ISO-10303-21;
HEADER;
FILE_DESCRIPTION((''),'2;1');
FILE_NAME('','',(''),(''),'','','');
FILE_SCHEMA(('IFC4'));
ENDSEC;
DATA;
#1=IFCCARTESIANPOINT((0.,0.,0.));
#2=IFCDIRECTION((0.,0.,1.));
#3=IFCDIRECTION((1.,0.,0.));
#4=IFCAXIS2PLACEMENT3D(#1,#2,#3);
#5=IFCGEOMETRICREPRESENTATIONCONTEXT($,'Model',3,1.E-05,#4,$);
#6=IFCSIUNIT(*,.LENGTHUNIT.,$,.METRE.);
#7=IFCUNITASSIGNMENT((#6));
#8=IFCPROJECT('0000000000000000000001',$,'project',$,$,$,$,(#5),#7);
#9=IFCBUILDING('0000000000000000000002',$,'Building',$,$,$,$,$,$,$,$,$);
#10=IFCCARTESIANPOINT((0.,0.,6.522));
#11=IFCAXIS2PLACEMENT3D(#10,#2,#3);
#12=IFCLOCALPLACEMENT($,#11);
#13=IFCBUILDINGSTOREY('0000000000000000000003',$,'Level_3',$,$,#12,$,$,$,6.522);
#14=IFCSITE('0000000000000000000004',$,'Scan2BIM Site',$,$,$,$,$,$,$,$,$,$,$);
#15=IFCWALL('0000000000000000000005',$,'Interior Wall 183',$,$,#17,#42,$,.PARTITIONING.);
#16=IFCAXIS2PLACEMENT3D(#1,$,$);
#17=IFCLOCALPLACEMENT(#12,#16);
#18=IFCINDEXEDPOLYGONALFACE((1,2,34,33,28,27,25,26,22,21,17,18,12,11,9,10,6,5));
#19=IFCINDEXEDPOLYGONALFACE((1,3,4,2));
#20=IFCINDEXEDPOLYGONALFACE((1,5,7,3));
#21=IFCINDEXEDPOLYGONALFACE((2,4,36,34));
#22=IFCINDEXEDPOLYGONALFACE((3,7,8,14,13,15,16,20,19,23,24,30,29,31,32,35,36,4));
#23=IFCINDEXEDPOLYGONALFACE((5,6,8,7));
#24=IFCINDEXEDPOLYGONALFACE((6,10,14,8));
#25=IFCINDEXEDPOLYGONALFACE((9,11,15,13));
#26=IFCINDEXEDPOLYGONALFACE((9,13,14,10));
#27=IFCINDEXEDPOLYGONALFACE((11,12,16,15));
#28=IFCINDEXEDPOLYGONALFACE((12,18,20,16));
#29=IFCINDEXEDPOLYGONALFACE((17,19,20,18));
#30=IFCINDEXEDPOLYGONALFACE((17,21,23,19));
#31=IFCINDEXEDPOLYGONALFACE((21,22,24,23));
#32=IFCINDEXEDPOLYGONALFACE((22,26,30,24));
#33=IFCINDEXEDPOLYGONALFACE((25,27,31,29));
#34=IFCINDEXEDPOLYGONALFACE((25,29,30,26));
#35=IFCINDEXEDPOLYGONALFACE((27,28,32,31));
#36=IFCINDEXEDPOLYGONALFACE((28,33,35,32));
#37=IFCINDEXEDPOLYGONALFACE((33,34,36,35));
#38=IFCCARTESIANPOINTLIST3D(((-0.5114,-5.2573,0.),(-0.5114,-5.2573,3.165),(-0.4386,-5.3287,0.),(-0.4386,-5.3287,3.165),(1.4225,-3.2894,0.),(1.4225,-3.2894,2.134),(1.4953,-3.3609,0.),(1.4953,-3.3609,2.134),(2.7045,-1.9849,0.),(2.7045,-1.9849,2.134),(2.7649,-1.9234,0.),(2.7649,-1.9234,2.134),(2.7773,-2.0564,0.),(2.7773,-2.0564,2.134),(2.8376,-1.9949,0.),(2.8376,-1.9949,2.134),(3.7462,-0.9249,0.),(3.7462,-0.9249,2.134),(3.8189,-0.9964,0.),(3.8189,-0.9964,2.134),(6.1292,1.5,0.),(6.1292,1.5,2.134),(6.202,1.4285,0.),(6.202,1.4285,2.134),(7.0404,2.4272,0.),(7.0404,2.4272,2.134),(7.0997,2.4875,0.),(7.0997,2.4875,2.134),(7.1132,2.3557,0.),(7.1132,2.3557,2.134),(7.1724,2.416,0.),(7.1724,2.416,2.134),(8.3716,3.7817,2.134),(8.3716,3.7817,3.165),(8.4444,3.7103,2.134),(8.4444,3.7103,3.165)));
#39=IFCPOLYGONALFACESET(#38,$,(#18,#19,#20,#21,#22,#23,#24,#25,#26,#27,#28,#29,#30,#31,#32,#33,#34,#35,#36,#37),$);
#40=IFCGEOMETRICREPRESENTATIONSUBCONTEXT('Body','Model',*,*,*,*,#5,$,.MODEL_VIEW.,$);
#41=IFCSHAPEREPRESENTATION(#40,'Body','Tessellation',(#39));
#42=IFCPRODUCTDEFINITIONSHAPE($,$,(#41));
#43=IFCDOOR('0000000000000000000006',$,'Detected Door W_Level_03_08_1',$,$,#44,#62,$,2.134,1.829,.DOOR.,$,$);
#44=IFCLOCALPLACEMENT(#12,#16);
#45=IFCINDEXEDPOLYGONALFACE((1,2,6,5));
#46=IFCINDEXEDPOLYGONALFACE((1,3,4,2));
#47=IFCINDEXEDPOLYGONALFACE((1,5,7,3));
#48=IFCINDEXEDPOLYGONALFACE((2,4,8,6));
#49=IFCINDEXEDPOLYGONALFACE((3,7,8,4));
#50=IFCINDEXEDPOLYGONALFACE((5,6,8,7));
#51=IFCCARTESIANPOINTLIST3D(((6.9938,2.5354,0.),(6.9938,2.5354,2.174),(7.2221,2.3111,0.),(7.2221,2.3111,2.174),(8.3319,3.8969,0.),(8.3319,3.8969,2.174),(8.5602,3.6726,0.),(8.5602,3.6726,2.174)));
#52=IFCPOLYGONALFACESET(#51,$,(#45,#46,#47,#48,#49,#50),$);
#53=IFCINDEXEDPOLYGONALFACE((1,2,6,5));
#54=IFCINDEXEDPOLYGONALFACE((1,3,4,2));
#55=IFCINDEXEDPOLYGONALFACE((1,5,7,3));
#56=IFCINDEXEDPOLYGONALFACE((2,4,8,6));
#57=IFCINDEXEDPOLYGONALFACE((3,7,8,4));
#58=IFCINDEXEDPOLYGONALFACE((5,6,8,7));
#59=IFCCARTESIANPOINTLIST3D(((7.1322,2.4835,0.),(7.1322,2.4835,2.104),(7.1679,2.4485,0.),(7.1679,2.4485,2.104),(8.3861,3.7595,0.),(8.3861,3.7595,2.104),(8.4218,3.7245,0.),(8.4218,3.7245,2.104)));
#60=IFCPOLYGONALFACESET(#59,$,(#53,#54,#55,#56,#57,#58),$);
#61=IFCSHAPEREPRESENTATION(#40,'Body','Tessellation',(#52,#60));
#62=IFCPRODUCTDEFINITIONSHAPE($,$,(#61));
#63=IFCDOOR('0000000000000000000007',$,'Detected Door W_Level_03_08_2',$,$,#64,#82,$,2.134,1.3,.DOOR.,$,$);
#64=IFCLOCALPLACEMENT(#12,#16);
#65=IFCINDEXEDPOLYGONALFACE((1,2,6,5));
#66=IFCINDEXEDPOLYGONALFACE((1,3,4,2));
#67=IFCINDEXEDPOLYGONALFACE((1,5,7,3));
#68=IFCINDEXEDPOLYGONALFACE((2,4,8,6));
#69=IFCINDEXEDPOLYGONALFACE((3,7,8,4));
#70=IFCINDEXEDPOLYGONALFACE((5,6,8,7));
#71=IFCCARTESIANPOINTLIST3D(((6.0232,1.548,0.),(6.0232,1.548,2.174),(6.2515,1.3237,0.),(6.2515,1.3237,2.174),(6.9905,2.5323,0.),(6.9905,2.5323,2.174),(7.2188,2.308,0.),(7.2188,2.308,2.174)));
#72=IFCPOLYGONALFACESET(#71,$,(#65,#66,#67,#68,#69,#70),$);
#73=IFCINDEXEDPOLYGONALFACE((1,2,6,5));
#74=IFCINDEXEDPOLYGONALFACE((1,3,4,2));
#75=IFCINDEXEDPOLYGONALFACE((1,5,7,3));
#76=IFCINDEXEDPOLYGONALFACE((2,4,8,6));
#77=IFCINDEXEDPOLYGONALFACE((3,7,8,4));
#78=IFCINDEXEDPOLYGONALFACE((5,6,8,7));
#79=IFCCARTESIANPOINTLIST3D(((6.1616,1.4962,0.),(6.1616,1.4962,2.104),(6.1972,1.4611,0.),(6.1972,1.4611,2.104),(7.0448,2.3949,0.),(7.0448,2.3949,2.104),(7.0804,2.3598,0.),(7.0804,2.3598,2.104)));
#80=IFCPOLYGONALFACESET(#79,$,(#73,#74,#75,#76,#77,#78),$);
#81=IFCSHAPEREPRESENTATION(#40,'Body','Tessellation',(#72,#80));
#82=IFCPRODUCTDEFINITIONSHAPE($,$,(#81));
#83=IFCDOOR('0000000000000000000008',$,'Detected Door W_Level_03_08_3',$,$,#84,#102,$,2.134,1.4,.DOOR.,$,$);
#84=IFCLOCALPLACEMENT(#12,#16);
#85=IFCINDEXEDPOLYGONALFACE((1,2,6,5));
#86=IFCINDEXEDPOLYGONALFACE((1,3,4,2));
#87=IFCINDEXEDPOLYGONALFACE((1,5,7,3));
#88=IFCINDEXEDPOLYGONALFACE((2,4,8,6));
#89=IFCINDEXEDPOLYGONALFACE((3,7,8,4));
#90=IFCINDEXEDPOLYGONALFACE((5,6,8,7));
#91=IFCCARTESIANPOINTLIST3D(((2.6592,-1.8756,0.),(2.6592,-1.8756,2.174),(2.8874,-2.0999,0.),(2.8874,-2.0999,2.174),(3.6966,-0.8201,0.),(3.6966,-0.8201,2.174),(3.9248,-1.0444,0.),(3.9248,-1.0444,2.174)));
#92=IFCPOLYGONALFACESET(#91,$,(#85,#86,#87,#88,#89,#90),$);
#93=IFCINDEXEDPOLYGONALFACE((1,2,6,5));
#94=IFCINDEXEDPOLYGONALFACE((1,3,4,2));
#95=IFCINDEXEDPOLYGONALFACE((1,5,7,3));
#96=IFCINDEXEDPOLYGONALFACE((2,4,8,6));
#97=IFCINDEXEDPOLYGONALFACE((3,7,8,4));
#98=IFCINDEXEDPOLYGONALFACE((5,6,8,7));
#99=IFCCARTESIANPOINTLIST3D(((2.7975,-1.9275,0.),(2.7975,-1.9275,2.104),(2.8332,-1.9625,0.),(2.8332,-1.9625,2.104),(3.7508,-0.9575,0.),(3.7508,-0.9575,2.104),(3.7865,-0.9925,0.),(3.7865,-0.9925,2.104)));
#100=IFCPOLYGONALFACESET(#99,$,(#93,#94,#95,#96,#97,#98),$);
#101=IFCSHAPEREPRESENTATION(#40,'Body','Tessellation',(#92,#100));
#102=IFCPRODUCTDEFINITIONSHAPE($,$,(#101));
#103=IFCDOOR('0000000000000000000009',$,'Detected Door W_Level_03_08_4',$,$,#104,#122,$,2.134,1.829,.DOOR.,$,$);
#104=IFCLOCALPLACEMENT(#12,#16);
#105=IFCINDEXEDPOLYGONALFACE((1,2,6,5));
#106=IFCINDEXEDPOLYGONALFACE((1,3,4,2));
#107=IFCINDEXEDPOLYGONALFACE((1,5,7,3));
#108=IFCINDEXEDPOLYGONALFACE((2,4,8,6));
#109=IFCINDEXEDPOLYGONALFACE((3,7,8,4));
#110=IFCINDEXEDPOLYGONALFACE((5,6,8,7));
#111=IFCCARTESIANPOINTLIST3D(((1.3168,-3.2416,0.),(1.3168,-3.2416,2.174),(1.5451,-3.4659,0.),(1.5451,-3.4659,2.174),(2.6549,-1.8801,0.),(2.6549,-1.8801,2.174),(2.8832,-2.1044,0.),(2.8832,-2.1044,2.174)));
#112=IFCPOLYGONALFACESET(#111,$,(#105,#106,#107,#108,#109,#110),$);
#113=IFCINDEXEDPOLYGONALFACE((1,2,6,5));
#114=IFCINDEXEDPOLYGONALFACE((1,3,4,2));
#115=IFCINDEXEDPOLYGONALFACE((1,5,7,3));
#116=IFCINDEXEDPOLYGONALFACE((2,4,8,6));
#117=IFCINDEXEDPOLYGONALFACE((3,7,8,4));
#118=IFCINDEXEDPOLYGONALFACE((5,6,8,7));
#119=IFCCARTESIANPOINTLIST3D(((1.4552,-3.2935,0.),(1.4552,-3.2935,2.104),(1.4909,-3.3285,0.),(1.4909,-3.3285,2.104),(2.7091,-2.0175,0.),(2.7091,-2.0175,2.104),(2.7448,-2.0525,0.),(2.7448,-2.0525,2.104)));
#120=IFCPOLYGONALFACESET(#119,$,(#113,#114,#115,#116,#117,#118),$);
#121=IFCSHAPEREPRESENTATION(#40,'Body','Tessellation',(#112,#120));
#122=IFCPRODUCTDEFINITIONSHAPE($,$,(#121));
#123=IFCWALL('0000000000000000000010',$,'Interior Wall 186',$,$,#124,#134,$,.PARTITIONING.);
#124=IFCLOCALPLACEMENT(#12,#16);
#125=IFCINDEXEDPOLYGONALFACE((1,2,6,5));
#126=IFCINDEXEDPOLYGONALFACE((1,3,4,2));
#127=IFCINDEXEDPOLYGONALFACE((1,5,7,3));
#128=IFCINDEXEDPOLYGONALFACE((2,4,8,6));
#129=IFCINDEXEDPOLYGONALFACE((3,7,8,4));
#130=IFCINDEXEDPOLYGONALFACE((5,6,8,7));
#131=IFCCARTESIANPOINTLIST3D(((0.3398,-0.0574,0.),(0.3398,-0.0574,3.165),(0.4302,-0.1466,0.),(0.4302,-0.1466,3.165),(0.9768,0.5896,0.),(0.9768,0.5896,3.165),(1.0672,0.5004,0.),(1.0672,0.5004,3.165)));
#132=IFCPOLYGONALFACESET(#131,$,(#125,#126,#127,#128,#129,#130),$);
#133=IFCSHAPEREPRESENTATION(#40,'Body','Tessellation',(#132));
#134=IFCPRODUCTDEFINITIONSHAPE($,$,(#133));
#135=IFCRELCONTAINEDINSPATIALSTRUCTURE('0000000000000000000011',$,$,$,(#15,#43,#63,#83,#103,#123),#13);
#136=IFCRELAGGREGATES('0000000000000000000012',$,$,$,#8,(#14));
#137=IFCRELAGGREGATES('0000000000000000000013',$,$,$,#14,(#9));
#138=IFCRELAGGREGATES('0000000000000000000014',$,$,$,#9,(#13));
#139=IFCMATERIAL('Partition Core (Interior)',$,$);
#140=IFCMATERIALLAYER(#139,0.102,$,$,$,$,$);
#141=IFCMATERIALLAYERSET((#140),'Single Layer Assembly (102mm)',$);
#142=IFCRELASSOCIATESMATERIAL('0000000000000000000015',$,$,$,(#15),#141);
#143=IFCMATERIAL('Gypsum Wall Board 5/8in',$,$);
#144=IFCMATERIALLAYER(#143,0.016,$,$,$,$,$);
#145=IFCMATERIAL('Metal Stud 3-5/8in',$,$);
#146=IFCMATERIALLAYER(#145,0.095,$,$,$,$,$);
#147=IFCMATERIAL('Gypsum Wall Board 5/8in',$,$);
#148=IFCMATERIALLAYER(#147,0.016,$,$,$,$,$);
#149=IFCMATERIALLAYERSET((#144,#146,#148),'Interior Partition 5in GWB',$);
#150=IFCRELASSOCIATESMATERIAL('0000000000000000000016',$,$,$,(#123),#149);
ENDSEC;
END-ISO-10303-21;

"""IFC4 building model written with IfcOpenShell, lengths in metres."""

from ifc_helpers import new_model, si_unit, frame, origin, origin_with_axes, place, context, subcontext, project, spatial, rectangle, extrude, material, layer, layer_set, element, fill, save


model = new_model("IFC4")

# Units and contexts
model_context = context("Model", 3, precision=1e-05, world=origin_with_axes())
body_context = subcontext(model_context, "Body", "Model", "MODEL_VIEW")
ifc_project = project(units=[si_unit("LENGTHUNIT", "METRE")], contexts=[model_context])

# Site, building, storey
site = spatial("IfcSite", under=ifc_project, Name="Scan2BIM Site")
building = spatial("IfcBuilding", under=site, Name="Building")
storey_placement = place(None, frame((0.0, 0.0, 6.522), z_axis=(0.0, 0.0, 1.0), x_axis=(1.0, 0.0, 0.0)))
storey = spatial("IfcBuildingStorey", under=building, at=storey_placement, Name="Level_3", Elevation=6.522)

# Wall, openings, doors
ifc_material_1 = material(Name="Partition Core (Interior)")
ifc_layer_1 = layer(ifc_material_1, 0.102)
ifc_layer_set_1 = layer_set([ifc_layer_1], Name="Single Layer Assembly (102mm)")
wall_1_placement = place(storey_placement, frame((3.9665, -0.7735, 0.0), z_axis=(0.0, 0.0, 1.0), x_axis=(-0.700925, -0.713235, 0.0)))
wall_1 = element("IfcWall", 1, at=wall_1_placement, inside=storey, material=ifc_layer_set_1, Name="Interior Wall 183", PredefinedType="PARTITIONING", context=body_context, shape_type="SweptSolid", body=[
    extrude(rectangle(XDim=12.6732, YDim=0.102), origin(), (0.0, 0.0, 1.0), 3.165),
])
opening_1_placement = place(None, frame((7.777, 3.104, 6.522), z_axis=(0.0, 0.0, 1.0), x_axis=(-0.700925, -0.713235, 0.0)))
opening_1 = element("IfcOpeningElement", 2, at=opening_1_placement, cuts=wall_1, PredefinedType="OPENING", context=body_context, shape_type="SweptSolid", body=[
    extrude(rectangle(XDim=1.829, YDim=0.202), origin(), (0.0, 0.0, 1.0), 2.134),
])
opening_2_placement = place(None, frame((6.621, 1.928, 6.522), z_axis=(0.0, 0.0, 1.0), x_axis=(-0.700925, -0.713235, 0.0)))
opening_2 = element("IfcOpeningElement", 3, at=opening_2_placement, cuts=wall_1, PredefinedType="OPENING", context=body_context, shape_type="SweptSolid", body=[
    extrude(rectangle(XDim=1.3, YDim=0.202), origin(), (0.0, 0.0, 1.0), 2.134),
])
opening_3_placement = place(None, frame((3.292, -1.46, 6.522), z_axis=(0.0, 0.0, 1.0), x_axis=(-0.700925, -0.713235, 0.0)))
opening_3 = element("IfcOpeningElement", 4, at=opening_3_placement, cuts=wall_1, PredefinedType="OPENING", context=body_context, shape_type="SweptSolid", body=[
    extrude(rectangle(XDim=1.4, YDim=0.202), origin(), (0.0, 0.0, 1.0), 2.134),
])
opening_4_placement = place(None, frame((2.1, -2.673, 6.522), z_axis=(0.0, 0.0, 1.0), x_axis=(-0.700925, -0.713235, 0.0)))
opening_4 = element("IfcOpeningElement", 5, at=opening_4_placement, cuts=wall_1, PredefinedType="OPENING", context=body_context, shape_type="SweptSolid", body=[
    extrude(rectangle(XDim=1.829, YDim=0.202), origin(), (0.0, 0.0, 1.0), 2.134),
])
door_1_placement = place(opening_1_placement, frame((0.0, 0.0, 0.0), z_axis=(0.0, 0.0, 1.0), x_axis=(1.0, 0.0, 0.0)))
door_1 = element("IfcDoor", 6, at=door_1_placement, inside=storey, Name="Detected Door W_Level_03_08_1", OverallHeight=2.134, OverallWidth=1.829, PredefinedType="DOOR", context=body_context, shape_type="SweptSolid", body=[
    extrude(rectangle(XDim=1.909, YDim=0.32), origin(), (0.0, 0.0, 1.0), 2.174),
    extrude(rectangle(XDim=1.789, YDim=0.05), origin(), (0.0, 0.0, 1.0), 2.104),
])
fill(opening_1, door_1)
door_2_placement = place(opening_2_placement, frame((0.0, 0.0, 0.0), z_axis=(0.0, 0.0, 1.0), x_axis=(1.0, 0.0, 0.0)))
door_2 = element("IfcDoor", 7, at=door_2_placement, inside=storey, Name="Detected Door W_Level_03_08_2", OverallHeight=2.134, OverallWidth=1.3, PredefinedType="DOOR", context=body_context, shape_type="SweptSolid", body=[
    extrude(rectangle(XDim=1.38, YDim=0.32), origin(), (0.0, 0.0, 1.0), 2.174),
    extrude(rectangle(XDim=1.26, YDim=0.05), origin(), (0.0, 0.0, 1.0), 2.104),
])
fill(opening_2, door_2)
door_3_placement = place(opening_3_placement, frame((0.0, 0.0, 0.0), z_axis=(0.0, 0.0, 1.0), x_axis=(1.0, 0.0, 0.0)))
door_3 = element("IfcDoor", 8, at=door_3_placement, inside=storey, Name="Detected Door W_Level_03_08_3", OverallHeight=2.134, OverallWidth=1.4, PredefinedType="DOOR", context=body_context, shape_type="SweptSolid", body=[
    extrude(rectangle(XDim=1.48, YDim=0.32), origin(), (0.0, 0.0, 1.0), 2.174),
    extrude(rectangle(XDim=1.36, YDim=0.05), origin(), (0.0, 0.0, 1.0), 2.104),
])
fill(opening_3, door_3)
door_4_placement = place(opening_4_placement, frame((0.0, 0.0, 0.0), z_axis=(0.0, 0.0, 1.0), x_axis=(1.0, 0.0, 0.0)))
door_4 = element("IfcDoor", 9, at=door_4_placement, inside=storey, Name="Detected Door W_Level_03_08_4", OverallHeight=2.134, OverallWidth=1.829, PredefinedType="DOOR", context=body_context, shape_type="SweptSolid", body=[
    extrude(rectangle(XDim=1.909, YDim=0.32), origin(), (0.0, 0.0, 1.0), 2.174),
    extrude(rectangle(XDim=1.789, YDim=0.05), origin(), (0.0, 0.0, 1.0), 2.104),
])
fill(opening_4, door_4)

# Wall
ifc_material_2 = material(Name="Gypsum Wall Board 5/8in")
ifc_layer_2 = layer(ifc_material_2, 0.016)
ifc_material_3 = material(Name="Metal Stud 3-5/8in")
ifc_layer_3 = layer(ifc_material_3, 0.095)
ifc_material_4 = material(Name="Gypsum Wall Board 5/8in")
ifc_layer_4 = layer(ifc_material_4, 0.016)
ifc_layer_set_2 = layer_set([ifc_layer_2, ifc_layer_3, ifc_layer_4], Name="Interior Partition 5in GWB")
wall_2_placement = place(storey_placement, frame((0.7035, 0.2215, 0.0), z_axis=(0.0, 0.0, 1.0), x_axis=(0.701578, 0.712592, 0.0)))
element("IfcWall", 10, at=wall_2_placement, inside=storey, material=ifc_layer_set_2, Name="Interior Wall 186", PredefinedType="PARTITIONING", context=body_context, shape_type="SweptSolid", body=[
    extrude(rectangle(XDim=0.908, YDim=0.127), origin(), (0.0, 0.0, 1.0), 3.165),
])

save(model, "model.ifc")
